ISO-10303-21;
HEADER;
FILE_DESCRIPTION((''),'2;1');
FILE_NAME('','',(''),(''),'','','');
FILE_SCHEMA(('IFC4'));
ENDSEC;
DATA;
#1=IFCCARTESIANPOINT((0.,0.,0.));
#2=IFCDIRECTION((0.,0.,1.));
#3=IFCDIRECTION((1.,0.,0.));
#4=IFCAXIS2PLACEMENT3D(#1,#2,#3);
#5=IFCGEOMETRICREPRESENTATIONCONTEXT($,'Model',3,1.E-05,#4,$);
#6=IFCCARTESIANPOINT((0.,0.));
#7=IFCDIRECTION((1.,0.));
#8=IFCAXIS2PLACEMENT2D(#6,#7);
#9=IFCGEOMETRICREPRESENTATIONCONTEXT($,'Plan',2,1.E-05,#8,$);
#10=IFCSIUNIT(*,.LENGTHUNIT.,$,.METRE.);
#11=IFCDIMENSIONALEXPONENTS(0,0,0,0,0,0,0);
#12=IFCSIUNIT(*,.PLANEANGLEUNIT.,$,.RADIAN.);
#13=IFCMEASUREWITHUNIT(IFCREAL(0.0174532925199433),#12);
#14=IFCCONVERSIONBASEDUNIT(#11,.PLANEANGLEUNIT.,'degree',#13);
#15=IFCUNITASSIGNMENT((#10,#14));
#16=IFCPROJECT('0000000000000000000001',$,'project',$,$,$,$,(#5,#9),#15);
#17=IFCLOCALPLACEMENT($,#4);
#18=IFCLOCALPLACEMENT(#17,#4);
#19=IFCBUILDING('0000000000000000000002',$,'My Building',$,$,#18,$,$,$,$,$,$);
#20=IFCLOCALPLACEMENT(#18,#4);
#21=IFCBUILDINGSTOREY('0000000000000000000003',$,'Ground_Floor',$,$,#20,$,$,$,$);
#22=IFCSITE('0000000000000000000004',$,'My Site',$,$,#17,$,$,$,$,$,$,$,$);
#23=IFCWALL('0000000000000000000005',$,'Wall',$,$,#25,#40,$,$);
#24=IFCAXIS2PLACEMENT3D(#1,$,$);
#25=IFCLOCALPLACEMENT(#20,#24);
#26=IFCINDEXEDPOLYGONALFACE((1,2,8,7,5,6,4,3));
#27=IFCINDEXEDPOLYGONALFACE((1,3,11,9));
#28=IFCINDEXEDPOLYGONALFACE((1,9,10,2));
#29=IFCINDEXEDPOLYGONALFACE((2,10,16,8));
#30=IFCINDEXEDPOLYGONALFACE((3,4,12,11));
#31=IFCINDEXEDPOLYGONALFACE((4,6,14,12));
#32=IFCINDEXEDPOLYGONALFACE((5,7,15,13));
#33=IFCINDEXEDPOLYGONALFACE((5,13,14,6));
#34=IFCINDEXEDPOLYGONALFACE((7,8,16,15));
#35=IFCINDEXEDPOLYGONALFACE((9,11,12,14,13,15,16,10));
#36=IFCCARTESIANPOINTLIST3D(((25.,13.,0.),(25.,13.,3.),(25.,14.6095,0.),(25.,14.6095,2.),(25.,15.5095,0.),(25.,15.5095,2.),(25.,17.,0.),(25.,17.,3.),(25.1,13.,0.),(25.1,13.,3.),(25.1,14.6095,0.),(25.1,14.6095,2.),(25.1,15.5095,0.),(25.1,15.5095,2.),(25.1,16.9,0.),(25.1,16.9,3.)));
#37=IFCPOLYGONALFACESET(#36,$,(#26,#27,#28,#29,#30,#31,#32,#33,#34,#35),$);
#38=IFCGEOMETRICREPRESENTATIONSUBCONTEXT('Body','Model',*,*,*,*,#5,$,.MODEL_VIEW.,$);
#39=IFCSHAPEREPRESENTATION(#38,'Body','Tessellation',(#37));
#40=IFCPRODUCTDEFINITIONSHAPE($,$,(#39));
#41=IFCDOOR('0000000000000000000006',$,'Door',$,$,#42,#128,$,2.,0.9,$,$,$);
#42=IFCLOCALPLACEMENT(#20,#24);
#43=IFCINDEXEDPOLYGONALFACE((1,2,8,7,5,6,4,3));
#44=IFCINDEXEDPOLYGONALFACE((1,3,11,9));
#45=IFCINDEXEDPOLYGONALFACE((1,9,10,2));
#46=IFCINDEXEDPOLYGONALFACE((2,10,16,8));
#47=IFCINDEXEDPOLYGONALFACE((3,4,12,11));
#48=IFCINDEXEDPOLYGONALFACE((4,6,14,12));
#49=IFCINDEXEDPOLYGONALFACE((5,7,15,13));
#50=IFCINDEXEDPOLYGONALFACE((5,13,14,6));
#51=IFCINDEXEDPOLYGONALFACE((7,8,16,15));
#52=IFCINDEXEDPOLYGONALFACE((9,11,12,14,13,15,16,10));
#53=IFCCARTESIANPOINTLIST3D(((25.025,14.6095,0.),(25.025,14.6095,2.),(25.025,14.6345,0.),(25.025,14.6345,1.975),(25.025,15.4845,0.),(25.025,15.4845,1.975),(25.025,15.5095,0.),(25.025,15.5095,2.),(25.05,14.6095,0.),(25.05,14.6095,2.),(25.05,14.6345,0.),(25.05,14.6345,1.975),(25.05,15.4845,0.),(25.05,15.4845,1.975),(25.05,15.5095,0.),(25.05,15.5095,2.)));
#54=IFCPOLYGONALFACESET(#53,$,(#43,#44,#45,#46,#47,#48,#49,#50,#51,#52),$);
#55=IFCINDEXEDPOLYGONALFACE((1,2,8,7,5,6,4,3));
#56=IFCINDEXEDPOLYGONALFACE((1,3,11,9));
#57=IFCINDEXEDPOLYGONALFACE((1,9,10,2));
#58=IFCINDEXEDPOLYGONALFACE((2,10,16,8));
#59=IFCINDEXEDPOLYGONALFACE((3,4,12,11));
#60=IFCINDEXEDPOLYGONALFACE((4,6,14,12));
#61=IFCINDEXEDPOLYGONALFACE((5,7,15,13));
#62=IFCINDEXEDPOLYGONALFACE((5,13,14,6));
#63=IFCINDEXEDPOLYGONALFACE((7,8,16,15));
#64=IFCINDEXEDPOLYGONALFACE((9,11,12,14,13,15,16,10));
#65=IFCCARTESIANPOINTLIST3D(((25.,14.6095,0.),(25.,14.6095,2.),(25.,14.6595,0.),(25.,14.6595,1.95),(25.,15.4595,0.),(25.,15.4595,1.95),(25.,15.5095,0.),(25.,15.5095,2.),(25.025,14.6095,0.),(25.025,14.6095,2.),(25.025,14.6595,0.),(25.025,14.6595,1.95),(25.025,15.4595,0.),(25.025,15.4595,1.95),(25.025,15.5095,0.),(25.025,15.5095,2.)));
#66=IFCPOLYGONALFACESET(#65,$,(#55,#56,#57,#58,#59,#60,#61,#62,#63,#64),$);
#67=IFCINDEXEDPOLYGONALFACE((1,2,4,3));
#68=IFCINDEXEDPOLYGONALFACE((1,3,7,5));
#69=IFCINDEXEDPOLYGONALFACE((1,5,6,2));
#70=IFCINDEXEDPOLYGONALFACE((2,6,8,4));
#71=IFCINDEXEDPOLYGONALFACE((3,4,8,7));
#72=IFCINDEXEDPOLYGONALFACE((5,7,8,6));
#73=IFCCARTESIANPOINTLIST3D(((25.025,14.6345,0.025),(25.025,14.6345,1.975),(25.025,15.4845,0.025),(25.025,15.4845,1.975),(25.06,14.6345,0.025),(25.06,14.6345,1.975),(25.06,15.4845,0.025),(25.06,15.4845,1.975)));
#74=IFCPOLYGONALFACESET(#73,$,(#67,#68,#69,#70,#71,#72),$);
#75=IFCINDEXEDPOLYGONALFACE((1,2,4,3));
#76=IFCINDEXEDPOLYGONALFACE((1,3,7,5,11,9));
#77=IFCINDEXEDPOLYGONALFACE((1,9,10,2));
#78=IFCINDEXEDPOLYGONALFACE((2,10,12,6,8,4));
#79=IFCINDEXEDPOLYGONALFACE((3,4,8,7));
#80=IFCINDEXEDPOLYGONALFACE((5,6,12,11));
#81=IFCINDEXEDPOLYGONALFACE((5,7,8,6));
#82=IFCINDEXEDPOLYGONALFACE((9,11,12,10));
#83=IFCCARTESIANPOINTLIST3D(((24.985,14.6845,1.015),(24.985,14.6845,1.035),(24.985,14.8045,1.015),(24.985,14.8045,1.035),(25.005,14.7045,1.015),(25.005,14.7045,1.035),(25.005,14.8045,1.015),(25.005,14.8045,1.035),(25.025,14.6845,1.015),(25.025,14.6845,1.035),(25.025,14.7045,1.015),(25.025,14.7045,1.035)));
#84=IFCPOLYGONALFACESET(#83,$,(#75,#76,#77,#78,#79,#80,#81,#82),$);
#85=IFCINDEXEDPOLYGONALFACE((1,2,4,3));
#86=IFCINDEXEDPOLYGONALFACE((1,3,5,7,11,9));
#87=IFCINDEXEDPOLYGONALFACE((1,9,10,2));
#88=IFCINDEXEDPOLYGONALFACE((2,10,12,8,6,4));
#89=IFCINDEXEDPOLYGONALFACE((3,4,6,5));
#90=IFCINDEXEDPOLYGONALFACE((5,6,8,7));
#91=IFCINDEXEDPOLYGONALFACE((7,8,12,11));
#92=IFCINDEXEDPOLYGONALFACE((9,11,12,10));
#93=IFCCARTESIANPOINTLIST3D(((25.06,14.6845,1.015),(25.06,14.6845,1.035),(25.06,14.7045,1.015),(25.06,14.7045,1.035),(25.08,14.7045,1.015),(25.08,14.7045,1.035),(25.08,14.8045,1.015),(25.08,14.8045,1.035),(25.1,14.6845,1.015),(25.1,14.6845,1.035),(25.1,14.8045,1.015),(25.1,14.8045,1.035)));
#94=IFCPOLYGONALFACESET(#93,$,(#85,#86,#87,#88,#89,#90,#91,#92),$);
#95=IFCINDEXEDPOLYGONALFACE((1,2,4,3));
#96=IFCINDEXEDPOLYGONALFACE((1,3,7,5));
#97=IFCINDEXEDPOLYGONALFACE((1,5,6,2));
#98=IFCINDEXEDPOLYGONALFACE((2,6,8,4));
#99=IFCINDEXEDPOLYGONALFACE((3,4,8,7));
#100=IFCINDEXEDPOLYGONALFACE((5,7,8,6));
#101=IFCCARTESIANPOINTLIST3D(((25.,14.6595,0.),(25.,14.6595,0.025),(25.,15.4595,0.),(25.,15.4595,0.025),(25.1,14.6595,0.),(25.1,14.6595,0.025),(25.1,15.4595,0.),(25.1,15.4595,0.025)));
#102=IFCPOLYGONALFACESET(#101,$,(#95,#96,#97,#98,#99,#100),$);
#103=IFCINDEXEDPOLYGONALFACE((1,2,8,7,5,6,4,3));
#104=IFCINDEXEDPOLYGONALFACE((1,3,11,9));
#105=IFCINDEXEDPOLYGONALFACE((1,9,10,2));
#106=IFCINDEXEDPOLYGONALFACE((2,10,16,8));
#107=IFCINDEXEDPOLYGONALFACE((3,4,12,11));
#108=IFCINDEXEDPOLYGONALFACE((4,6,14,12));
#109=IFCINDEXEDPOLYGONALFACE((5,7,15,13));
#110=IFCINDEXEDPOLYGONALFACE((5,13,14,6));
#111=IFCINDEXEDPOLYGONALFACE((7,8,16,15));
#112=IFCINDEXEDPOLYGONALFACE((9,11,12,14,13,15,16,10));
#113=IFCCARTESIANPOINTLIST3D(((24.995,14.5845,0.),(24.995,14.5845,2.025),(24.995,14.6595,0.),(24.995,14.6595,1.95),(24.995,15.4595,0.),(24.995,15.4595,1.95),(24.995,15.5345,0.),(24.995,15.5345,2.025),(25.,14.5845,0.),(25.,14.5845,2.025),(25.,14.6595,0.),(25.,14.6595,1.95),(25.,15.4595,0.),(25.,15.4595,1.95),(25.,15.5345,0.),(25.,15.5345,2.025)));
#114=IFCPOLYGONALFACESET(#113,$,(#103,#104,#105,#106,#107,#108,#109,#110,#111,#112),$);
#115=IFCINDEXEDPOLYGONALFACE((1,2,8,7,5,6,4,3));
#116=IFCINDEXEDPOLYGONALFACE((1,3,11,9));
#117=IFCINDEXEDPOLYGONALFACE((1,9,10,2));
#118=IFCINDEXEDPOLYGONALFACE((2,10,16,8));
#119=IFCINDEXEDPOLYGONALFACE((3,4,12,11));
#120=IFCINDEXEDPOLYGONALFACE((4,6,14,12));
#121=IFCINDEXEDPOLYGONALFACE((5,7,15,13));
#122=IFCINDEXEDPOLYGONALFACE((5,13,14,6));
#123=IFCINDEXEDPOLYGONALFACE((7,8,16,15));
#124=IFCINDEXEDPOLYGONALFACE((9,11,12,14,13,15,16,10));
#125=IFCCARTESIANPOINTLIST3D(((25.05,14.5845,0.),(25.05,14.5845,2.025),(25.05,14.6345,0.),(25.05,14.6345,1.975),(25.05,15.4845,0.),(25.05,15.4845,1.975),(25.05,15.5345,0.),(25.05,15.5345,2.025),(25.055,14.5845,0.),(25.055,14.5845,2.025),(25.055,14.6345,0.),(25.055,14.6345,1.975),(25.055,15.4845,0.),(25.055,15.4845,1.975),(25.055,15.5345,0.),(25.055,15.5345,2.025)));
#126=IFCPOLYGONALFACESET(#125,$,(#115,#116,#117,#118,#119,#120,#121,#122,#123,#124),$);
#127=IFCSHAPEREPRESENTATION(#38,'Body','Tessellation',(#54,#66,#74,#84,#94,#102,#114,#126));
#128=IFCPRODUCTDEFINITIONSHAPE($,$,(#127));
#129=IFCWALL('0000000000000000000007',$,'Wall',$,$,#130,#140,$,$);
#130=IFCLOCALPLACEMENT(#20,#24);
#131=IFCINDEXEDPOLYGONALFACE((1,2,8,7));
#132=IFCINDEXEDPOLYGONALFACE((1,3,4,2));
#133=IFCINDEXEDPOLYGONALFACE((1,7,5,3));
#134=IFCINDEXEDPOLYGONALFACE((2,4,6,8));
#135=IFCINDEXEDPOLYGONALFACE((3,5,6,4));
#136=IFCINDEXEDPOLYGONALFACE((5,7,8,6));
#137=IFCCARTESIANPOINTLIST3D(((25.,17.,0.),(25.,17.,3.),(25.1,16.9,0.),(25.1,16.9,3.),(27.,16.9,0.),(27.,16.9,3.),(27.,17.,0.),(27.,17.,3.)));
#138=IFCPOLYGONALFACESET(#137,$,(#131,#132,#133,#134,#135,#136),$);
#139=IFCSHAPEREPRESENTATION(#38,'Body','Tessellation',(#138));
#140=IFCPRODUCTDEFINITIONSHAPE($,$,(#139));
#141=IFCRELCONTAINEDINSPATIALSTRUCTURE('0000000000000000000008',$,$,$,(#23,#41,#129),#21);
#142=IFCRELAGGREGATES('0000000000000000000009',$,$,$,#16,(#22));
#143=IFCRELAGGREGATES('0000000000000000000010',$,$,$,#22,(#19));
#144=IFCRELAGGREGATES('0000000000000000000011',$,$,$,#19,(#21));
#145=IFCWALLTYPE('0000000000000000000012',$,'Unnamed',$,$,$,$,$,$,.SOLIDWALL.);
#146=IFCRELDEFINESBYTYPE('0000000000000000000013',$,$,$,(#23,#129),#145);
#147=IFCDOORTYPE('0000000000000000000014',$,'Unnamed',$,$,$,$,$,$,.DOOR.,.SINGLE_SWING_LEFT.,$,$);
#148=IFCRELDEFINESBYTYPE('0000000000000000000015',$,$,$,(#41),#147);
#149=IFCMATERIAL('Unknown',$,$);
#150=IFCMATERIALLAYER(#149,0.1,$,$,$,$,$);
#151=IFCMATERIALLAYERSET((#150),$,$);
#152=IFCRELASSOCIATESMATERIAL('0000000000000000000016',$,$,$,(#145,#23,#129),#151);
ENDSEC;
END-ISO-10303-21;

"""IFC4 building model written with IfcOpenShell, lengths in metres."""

from ifc_helpers import new_model, entity, si_unit, converted_unit, frame, origin_with_axes, origin_2d_with_axis, place, context, subcontext, project, spatial, line, indexed_curve, outline, extrude, shape, source, transform, mapped, material, layer, layer_set, layer_usage, type_object, type_shapes, element, fill, save


model = new_model("IFC4")

# Units and contexts
model_context = context("Model", 3, precision=1e-05, world=origin_with_axes())
plan_context = context("Plan", 2, precision=1e-05, world=origin_2d_with_axis())
body_context_1 = subcontext(model_context, "Body", "Model", "MODEL_VIEW")
body_context_2 = subcontext(plan_context, "Body", "Plan", "PLAN_VIEW")
ifc_project = project(units=[si_unit("LENGTHUNIT", "METRE"), converted_unit("PLANEANGLEUNIT", "degree", entity("IfcReal", 0.0174532925199433), si_unit("PLANEANGLEUNIT", "RADIAN"), dimensions=[0, 0, 0, 0, 0, 0, 0])], contexts=[model_context, plan_context])

# Site, building, storey
site_placement = place(None, origin_with_axes())
site = spatial("IfcSite", under=ifc_project, at=site_placement, Name="My Site")
building_placement = place(site_placement, origin_with_axes())
building = spatial("IfcBuilding", under=site, at=building_placement, Name="My Building")
storey_placement = place(building_placement, origin_with_axes())
storey = spatial("IfcBuildingStorey", under=building, at=storey_placement, Name="Ground_Floor")

# Shared definitions
ifc_material = material(Name="Unknown")
ifc_layer = layer(ifc_material, 0.1)
ifc_layer_set = layer_set([ifc_layer])
wall_type = type_object("IfcWallType", Name="Unnamed", PredefinedType="SOLIDWALL", material=ifc_layer_set)

# Shared definitions
shared_shape_1 = source(origin_with_axes(), body_context_1, "Body", "SweptSolid", [
    extrude(outline(indexed_curve([(0.0, 0.0), (0.9, 0.0), (0.9, 2.0), (0.0, 2.0)], segments=[line(1, 2, 3, 4, 1)])), frame((0.0, -0.6, 0.0), z_axis=(0.0, -1.0, 0.0), x_axis=(1.0, 0.0, 0.0)), (0.0, 0.0, -1.0), 1.2),
])
door_type_1 = type_object("IfcDoorType", Name="Unnamed", OperationType="SINGLE_SWING_LEFT", PredefinedType="DOOR")
shared_shape_2 = source(origin_with_axes(), body_context_1, "Body", "SweptSolid", [
    extrude(outline(indexed_curve([(0.0, 0.0), (0.0, 2.0), (0.9, 2.0), (0.9, 0.0), (0.875, 0.0), (0.875, 1.975), (0.025, 1.975), (0.025, 0.0)], segments=[line(1, 2, 3, 4, 5, 6, 7, 8, 1)])), frame((0.0, 0.025, 0.0), z_axis=(0.0, -1.0, 0.0), x_axis=(1.0, 0.0, 0.0)), (0.0, 0.0, -1.0), 0.025),
    extrude(outline(indexed_curve([(0.0, 0.0), (0.0, 2.0), (0.9, 2.0), (0.9, 0.0), (0.85, 0.0), (0.85, 1.95), (0.05, 1.95), (0.05, 0.0)], segments=[line(1, 2, 3, 4, 5, 6, 7, 8, 1)])), frame((0.0, 0.0, 0.0), z_axis=(0.0, -1.0, 0.0), x_axis=(1.0, 0.0, 0.0)), (0.0, 0.0, -1.0), 0.025),
    extrude(outline(indexed_curve([(0.0, 0.0), (0.85, 0.0), (0.85, 0.035), (0.0, 0.035)], segments=[line(1, 2, 3, 4, 1)])), frame((0.025, 0.025, 0.025), z_axis=(0.0, 0.0, 1.0), x_axis=(1.0, 0.0, 0.0)), (0.0, 0.0, 1.0), 1.95),
    extrude(outline(indexed_curve([(0.0, 0.0), (0.0, -0.04), (-0.12, -0.04), (-0.12, -0.02), (-0.02, -0.02), (-0.02, 0.0)], segments=[line(1, 2, 3, 4, 5, 6, 1)])), frame((0.825, 0.025, 1.015), z_axis=(0.0, 0.0, 1.0), x_axis=(1.0, 0.0, 0.0)), (0.0, 0.0, 1.0), 0.02),
    extrude(outline(indexed_curve([(0.0, 0.0), (0.0, 0.04), (-0.12, 0.04), (-0.12, 0.02), (-0.02, 0.02), (-0.02, 0.0)], segments=[line(1, 2, 3, 4, 5, 6, 1)])), frame((0.825, 0.06, 1.015), z_axis=(0.0, 0.0, 1.0), x_axis=(1.0, 0.0, 0.0)), (0.0, 0.0, 1.0), 0.02),
    extrude(outline(indexed_curve([(0.0, 0.0), (0.8, 0.0), (0.8, 0.1), (0.0, 0.1)], segments=[line(1, 2, 3, 4, 1)])), frame((0.05, 0.0, 0.0), z_axis=(0.0, 0.0, 1.0), x_axis=(1.0, 0.0, 0.0)), (0.0, 0.0, 1.0), 0.025),
    extrude(outline(indexed_curve([(0.0, 0.0), (0.0, 2.025), (0.95, 2.025), (0.95, 0.0), (0.875, 0.0), (0.875, 1.95), (0.075, 1.95), (0.075, 0.0)], segments=[line(1, 2, 3, 4, 5, 6, 7, 8, 1)])), frame((-0.025, -0.005, 0.0), z_axis=(0.0, -1.0, 0.0), x_axis=(1.0, 0.0, 0.0)), (0.0, 0.0, -1.0), 0.005),
    extrude(outline(indexed_curve([(0.0, 0.0), (0.0, 2.025), (0.95, 2.025), (0.95, 0.0), (0.9, 0.0), (0.9, 1.975), (0.05, 1.975), (0.05, 0.0)], segments=[line(1, 2, 3, 4, 5, 6, 7, 8, 1)])), frame((-0.025, 0.05, 0.0), z_axis=(0.0, -1.0, 0.0), x_axis=(1.0, 0.0, 0.0)), (0.0, 0.0, -1.0), 0.005),
])
shared_shape_3 = source(origin_with_axes(), body_context_2, "Body", "Curve2D", [
    entity("IfcIndexedPolyCurve", entity("IfcCartesianPointList2D", [[0.0, 0.0], [0.0, 0.05], [0.025, 0.05], [0.025, 0.025], [0.05, 0.025], [0.05, 0.0]]), [entity("IfcLineIndex", [1, 2, 3, 4, 5, 6, 1])]),
    entity("IfcIndexedPolyCurve", entity("IfcCartesianPointList2D", [[0.9, 0.0], [0.9, 0.05], [0.875, 0.05], [0.875, 0.025], [0.85, 0.025], [0.85, 0.0]]), [entity("IfcLineIndex", [1, 2, 3, 4, 5, 6, 1])]),
    entity("IfcTrimmedCurve", entity("IfcEllipse", entity("IfcAxis2Placement2D", entity("IfcCartesianPoint", [0.06, 0.05]), entity("IfcDirection", [1.0, 0.0])), 0.815, 0.85), [entity("IfcCartesianPoint", [0.875, 0.05])], [entity("IfcCartesianPoint", [0.06, 0.9])], True, "CARTESIAN"),
    entity("IfcIndexedPolyCurve", entity("IfcCartesianPointList2D", [[0.025, 0.05], [0.06, 0.05], [0.06, 0.9], [0.025, 0.9]]), [entity("IfcLineIndex", [1, 2, 3, 4, 1])]),
])
type_shapes(door_type_1, [shared_shape_2, shared_shape_3])

# Wall, opening, door
ifc_layer_usage_1 = layer_usage(ifc_layer_set, "AXIS2", "POSITIVE", 0.0)
wall_1_placement = place(storey_placement, frame((25.0, 17.0, 0.0), z_axis=(0.0, 0.0, 1.0), x_axis=(0.0, -1.0, 0.0)))
wall_1 = element("IfcWall", 1, at=wall_1_placement, inside=storey, type_object=wall_type, material=ifc_layer_usage_1, Name="Wall", context=body_context_1, shape_type="SweptSolid", body=[
    extrude(outline(indexed_curve([(0.0, 0.0), (0.1, 0.1), (4.0, 0.1), (4.0, 0.0)], segments=[line(1, 2, 3, 4, 1)])), origin_with_axes(), (0.0, 0.0, 1.0), 3.0),
])
opening_1_placement = place(wall_1_placement, frame((1.4905, 0.0, 0.0), z_axis=(0.0, 0.0, 1.0), x_axis=(1.0, 0.0, 0.0)))
opening_1 = element("IfcOpeningElement", 2, at=opening_1_placement, cuts=wall_1, PredefinedType="OPENING", context=body_context_1, shape_type="MappedRepresentation", body=[
    mapped(shared_shape_1, transform((0.0, 0.0, 0.0), x_axis=(1.0, 0.0, 0.0), y_axis=(0.0, 1.0, 0.0), z_axis=(0.0, 0.0, 1.0), scale=1.0)),
])
door_1_placement = place(opening_1_placement, origin_with_axes())
door_1 = element("IfcDoor", 3, at=door_1_placement, inside=storey, type_object=door_type_1, Name="Door", OverallHeight=2.0, OverallWidth=0.9, shapes=[
    shape(body_context_1, "Body", "MappedRepresentation", [mapped(shared_shape_2, transform((0.0, 0.0, 0.0), x_axis=(1.0, 0.0, 0.0), y_axis=(0.0, 1.0, 0.0), z_axis=(0.0, 0.0, 1.0), scale=1.0))]),
    shape(body_context_2, "Body", "MappedRepresentation", [mapped(shared_shape_3, transform((0.0, 0.0, 0.0), x_axis=(1.0, 0.0, 0.0), y_axis=(0.0, 1.0, 0.0), z_axis=(0.0, 0.0, 1.0), scale=1.0))]),
])
fill(opening_1, door_1)

# Wall
ifc_layer_usage_2 = layer_usage(ifc_layer_set, "AXIS2", "POSITIVE", 0.0)
wall_2_placement = place(storey_placement, frame((27.0, 17.0, 0.0), z_axis=(0.0, 0.0, 1.0), x_axis=(-1.0, 0.0, 0.0)))
element("IfcWall", 4, at=wall_2_placement, inside=storey, type_object=wall_type, material=ifc_layer_usage_2, Name="Wall", context=body_context_1, shape_type="SweptSolid", body=[
    extrude(outline(indexed_curve([(0.0, 0.0), (0.0, 0.1), (1.9, 0.1), (2.0, 0.0)], segments=[line(1, 2, 3, 4, 1)])), origin_with_axes(), (0.0, 0.0, 1.0), 3.0),
])

save(model, "model.ifc")
